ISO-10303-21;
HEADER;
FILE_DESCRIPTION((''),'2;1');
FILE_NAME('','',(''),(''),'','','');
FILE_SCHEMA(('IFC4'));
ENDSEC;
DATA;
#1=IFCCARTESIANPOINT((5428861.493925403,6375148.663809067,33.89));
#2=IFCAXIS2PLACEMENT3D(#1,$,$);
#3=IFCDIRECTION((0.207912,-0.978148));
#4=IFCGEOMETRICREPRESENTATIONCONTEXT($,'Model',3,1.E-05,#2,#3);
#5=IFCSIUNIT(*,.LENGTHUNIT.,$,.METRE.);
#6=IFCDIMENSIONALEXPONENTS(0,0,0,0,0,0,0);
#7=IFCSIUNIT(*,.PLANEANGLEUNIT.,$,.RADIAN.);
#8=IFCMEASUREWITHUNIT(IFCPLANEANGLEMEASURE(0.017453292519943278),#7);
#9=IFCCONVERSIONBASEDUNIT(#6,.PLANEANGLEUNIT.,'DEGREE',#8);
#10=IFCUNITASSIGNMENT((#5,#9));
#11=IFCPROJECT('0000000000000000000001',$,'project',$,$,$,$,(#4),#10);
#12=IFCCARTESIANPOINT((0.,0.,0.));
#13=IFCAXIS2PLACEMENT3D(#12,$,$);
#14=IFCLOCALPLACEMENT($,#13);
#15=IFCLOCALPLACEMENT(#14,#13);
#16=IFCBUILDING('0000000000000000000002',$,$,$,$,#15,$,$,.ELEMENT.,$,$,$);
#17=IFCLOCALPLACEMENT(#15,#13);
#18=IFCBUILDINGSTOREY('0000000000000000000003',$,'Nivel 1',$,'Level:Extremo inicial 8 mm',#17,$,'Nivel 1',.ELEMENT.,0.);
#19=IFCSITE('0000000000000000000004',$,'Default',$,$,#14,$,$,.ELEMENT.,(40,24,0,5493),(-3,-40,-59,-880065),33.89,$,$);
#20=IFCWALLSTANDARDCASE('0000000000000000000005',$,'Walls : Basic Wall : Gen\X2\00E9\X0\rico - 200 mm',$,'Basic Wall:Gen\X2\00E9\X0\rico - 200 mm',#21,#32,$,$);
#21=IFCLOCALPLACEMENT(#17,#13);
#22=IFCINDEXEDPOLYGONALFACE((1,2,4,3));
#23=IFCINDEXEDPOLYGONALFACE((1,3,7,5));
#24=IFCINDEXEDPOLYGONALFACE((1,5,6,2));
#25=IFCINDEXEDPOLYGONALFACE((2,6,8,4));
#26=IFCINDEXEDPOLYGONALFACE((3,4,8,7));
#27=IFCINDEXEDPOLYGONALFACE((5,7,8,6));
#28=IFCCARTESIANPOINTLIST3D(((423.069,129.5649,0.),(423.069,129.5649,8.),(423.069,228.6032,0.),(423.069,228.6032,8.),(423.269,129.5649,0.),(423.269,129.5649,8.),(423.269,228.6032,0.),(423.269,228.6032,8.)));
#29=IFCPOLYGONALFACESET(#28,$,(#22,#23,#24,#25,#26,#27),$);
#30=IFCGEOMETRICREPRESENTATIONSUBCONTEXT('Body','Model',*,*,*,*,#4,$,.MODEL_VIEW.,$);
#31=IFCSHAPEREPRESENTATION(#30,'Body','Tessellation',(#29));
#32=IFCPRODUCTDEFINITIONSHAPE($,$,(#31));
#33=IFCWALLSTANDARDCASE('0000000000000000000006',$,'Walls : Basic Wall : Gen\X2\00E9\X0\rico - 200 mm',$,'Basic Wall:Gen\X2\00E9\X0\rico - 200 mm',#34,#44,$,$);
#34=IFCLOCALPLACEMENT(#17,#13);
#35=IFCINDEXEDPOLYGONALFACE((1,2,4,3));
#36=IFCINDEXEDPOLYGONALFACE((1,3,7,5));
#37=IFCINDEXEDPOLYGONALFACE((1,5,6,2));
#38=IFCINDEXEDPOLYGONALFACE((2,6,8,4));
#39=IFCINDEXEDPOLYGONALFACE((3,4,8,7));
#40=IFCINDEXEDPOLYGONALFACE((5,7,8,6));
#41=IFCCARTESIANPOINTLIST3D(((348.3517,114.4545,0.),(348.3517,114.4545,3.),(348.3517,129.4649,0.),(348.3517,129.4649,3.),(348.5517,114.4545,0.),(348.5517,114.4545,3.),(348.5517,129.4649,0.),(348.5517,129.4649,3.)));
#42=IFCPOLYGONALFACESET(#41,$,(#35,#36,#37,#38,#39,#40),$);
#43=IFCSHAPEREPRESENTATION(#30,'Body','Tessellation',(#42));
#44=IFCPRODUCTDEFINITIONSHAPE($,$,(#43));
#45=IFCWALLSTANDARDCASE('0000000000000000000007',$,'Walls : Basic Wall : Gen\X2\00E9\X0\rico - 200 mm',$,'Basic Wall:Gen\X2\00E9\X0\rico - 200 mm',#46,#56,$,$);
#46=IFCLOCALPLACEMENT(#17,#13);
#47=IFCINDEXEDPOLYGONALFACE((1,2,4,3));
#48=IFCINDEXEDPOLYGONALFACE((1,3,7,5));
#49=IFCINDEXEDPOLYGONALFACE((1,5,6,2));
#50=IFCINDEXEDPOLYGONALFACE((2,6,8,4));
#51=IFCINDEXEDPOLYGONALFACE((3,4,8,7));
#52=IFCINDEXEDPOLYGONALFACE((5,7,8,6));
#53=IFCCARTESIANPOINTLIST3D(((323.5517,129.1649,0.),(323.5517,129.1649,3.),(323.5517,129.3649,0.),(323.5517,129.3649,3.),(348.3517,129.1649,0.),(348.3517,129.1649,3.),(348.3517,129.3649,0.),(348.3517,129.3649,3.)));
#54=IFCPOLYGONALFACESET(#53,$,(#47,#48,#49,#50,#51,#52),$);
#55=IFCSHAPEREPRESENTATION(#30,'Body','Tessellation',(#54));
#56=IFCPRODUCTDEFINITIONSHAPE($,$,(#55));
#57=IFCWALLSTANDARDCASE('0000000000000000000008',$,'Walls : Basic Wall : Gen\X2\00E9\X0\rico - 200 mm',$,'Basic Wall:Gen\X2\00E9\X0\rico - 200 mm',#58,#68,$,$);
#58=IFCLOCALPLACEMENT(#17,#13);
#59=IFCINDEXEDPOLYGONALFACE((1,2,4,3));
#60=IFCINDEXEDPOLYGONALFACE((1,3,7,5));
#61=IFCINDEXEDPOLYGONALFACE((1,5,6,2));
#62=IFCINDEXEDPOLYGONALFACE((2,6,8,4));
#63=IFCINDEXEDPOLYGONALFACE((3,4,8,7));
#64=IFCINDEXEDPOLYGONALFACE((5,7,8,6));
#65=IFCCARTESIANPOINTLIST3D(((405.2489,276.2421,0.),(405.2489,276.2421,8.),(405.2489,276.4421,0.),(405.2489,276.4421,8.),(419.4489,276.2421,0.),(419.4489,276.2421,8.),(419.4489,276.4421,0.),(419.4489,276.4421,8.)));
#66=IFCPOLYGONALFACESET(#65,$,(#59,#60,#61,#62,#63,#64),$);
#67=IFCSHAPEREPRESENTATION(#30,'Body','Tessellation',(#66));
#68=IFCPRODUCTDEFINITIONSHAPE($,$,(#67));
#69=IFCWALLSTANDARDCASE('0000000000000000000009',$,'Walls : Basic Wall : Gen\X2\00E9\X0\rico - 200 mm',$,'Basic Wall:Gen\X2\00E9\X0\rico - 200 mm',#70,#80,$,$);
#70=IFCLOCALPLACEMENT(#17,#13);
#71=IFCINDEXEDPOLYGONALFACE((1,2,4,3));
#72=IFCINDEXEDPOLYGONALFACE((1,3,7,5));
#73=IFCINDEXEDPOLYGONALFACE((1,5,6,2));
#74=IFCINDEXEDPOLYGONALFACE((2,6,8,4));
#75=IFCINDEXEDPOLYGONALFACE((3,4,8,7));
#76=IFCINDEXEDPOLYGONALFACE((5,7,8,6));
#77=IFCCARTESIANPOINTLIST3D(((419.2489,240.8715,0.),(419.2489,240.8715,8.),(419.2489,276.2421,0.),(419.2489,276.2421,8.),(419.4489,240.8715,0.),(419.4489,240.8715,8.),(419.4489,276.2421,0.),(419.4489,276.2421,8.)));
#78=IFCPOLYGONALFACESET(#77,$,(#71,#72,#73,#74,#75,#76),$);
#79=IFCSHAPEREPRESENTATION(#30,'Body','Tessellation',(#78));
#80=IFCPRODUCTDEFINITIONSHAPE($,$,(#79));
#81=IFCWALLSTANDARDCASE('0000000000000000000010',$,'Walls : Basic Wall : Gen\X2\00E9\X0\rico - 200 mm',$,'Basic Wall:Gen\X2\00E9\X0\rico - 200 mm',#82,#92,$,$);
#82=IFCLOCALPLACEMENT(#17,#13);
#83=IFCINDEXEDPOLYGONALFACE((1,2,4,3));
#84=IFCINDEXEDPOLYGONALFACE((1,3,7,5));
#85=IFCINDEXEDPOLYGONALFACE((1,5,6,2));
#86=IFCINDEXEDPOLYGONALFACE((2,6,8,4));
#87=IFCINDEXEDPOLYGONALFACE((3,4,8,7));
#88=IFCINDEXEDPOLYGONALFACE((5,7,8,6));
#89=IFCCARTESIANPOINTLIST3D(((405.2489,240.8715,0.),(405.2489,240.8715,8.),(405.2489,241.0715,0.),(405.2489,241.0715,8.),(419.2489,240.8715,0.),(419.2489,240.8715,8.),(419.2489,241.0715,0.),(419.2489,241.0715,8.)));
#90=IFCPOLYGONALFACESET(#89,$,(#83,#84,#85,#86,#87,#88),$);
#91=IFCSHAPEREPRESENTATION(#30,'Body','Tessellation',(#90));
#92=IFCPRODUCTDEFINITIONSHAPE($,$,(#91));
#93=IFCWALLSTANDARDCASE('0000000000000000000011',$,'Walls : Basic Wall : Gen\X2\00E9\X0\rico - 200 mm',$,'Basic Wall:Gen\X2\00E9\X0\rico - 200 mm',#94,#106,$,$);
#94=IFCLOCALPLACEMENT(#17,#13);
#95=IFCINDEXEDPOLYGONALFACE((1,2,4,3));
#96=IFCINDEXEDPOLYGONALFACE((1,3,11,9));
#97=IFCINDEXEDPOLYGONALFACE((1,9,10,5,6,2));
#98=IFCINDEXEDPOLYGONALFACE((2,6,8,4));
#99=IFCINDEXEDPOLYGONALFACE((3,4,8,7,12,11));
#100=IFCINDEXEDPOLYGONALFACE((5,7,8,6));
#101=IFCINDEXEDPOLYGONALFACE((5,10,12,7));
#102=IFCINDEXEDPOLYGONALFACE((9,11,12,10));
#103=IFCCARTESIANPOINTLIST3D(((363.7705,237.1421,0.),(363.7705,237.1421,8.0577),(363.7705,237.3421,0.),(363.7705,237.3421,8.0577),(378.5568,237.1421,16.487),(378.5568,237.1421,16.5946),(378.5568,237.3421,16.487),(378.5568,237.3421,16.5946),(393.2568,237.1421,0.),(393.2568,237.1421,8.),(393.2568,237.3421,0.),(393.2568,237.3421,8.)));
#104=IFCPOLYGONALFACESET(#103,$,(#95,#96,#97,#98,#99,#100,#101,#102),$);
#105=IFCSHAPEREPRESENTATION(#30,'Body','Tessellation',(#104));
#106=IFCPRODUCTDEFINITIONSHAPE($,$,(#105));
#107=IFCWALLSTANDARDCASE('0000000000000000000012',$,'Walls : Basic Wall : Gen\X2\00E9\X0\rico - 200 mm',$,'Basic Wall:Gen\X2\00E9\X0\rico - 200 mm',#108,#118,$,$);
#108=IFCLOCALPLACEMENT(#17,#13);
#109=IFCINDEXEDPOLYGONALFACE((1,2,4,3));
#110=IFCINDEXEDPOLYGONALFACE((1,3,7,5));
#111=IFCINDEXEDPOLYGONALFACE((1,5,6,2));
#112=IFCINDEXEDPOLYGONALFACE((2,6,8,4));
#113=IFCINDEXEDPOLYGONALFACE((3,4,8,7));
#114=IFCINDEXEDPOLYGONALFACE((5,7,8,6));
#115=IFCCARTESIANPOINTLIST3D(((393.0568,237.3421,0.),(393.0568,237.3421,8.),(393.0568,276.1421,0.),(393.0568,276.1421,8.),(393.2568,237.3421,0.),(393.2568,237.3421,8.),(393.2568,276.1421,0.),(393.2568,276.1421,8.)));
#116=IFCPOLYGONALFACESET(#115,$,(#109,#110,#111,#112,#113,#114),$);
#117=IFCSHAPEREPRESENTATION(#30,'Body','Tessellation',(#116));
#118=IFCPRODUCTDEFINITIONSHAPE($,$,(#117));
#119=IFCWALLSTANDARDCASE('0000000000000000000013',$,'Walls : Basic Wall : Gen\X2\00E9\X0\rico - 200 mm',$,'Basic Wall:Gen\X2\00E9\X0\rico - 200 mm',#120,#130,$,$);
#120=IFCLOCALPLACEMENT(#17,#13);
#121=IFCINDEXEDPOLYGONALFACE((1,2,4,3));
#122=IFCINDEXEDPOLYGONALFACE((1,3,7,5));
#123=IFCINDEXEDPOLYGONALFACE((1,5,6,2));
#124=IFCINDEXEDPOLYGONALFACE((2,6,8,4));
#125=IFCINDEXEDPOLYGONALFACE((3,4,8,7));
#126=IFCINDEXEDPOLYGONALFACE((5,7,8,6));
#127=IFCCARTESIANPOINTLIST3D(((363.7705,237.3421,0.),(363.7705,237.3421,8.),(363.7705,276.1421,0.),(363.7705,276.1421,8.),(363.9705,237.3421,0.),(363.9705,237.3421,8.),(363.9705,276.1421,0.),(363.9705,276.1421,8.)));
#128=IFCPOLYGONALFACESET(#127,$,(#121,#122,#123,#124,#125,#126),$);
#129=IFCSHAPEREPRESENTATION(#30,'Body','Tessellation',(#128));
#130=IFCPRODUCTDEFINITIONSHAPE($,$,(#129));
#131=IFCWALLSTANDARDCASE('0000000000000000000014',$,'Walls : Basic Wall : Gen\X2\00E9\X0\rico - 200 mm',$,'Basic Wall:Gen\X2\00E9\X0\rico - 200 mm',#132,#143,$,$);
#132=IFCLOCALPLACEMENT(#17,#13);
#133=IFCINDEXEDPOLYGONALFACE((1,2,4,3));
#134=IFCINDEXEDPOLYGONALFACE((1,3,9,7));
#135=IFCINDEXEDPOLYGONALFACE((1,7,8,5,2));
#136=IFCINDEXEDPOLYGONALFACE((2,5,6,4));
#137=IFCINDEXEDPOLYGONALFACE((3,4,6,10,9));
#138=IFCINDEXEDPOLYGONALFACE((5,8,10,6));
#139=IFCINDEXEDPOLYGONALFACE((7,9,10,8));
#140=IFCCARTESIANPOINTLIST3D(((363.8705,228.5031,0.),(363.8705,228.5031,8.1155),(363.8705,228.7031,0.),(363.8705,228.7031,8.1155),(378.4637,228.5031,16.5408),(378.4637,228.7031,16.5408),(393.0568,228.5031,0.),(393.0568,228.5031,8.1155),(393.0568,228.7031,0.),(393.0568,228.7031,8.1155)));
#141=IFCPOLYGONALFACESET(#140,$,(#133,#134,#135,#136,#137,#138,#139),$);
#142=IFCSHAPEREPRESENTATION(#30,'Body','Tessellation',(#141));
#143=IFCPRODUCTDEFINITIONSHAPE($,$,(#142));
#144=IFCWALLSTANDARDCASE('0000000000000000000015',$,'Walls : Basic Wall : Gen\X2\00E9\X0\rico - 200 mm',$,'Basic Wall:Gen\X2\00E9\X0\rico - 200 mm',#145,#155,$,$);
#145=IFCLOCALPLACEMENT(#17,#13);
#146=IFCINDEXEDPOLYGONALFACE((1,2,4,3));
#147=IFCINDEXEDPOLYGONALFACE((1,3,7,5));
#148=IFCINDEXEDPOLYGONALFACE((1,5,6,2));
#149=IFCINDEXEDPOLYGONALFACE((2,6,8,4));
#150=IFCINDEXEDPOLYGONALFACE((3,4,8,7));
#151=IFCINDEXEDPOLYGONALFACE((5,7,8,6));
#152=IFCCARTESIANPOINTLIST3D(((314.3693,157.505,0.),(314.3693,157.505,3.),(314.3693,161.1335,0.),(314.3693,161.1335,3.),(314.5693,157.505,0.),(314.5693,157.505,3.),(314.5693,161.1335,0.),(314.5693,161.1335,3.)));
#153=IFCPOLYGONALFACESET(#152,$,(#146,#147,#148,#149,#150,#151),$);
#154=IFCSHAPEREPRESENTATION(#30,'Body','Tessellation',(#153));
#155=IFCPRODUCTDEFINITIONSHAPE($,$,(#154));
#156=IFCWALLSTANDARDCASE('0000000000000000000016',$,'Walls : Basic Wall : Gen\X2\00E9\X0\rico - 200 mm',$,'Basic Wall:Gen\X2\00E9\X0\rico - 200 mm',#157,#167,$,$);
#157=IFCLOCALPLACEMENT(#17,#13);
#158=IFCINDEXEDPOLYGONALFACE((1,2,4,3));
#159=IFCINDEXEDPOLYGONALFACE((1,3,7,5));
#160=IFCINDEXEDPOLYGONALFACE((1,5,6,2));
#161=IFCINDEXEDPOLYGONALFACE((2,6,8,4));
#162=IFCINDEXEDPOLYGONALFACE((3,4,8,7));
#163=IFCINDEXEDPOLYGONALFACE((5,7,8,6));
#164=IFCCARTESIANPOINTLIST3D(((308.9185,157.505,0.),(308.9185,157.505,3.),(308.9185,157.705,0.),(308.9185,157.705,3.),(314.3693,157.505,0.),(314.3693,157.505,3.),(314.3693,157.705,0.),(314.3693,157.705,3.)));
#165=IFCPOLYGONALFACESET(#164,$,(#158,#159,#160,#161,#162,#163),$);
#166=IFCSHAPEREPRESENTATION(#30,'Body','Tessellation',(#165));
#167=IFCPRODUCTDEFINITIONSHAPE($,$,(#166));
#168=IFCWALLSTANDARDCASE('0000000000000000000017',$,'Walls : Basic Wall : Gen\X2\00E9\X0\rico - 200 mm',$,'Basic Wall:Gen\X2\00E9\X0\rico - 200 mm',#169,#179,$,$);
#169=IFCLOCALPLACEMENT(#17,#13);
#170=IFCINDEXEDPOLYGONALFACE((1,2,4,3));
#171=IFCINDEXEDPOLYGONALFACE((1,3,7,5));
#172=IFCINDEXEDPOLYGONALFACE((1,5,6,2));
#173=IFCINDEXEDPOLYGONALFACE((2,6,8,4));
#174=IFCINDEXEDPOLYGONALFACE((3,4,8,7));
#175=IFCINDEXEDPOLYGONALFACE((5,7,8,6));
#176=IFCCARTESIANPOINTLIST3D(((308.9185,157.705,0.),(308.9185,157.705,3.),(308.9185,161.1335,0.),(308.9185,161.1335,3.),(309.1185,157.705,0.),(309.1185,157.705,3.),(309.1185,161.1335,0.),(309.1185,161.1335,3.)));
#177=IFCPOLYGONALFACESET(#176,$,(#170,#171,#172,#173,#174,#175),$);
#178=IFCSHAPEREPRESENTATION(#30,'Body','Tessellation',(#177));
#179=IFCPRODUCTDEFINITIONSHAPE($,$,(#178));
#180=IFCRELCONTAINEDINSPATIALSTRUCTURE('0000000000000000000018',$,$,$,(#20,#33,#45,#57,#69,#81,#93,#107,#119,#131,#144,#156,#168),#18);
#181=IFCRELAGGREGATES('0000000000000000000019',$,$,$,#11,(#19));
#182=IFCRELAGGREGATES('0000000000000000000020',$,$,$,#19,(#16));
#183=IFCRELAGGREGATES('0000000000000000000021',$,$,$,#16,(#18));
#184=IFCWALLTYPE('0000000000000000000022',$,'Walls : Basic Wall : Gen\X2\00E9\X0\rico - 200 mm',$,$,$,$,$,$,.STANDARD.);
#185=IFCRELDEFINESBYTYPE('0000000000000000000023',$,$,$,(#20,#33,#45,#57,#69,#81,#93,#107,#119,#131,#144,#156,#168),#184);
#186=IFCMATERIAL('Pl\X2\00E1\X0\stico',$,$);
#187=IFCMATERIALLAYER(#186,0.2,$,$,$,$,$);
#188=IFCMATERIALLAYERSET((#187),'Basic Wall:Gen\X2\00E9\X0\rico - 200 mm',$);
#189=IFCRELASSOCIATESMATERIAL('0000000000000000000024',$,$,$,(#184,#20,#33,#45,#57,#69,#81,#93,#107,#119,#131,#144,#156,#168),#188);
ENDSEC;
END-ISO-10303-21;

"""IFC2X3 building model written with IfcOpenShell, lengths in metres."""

from ifc_helpers import new_model, entity, si_unit, converted_unit, direction, frame, frame_2d, origin, place, context, subcontext, project, spatial, polyline, rectangle, extrude, clip, bounded_halfspace, material, layer, layer_set, layer_usage, type_object, element, save


model = new_model("IFC2X3")

# Units and contexts
model_context = context("Model", 3, precision=1e-05, world=frame((5428861.493925403, 6375148.663809067, 33.89)), true_north=direction((0.207912, -0.978148)))
body_context = subcontext(model_context, "Body", "Model", "MODEL_VIEW")
ifc_project = project(units=[si_unit("LENGTHUNIT", "METRE"), converted_unit("PLANEANGLEUNIT", "DEGREE", entity("IfcPlaneAngleMeasure", 0.017453292519943278), si_unit("PLANEANGLEUNIT", "RADIAN"), dimensions=[0, 0, 0, 0, 0, 0, 0])], contexts=[model_context])

# Site, building, storey
site_placement = place(None, origin())
site = spatial("IfcSite", under=ifc_project, at=site_placement, Name="Default", CompositionType="ELEMENT", RefLatitude=(40, 24, 0, 5493), RefLongitude=(-3, -40, -59, -880065), RefElevation=33.89)
building_placement = place(site_placement, origin())
building = spatial("IfcBuilding", under=site, at=building_placement, CompositionType="ELEMENT")
storey_placement = place(building_placement, origin())
storey = spatial("IfcBuildingStorey", under=building, at=storey_placement, Name="Nivel 1", ObjectType="Level:Extremo inicial 8 mm", LongName="Nivel 1", CompositionType="ELEMENT", Elevation=0.0)

# Walls
ifc_material = material(Name="Plástico")
ifc_layer = layer(ifc_material, 0.2)
ifc_layer_set = layer_set([ifc_layer], Name="Basic Wall:Genérico - 200 mm")
wall_type = type_object("IfcWallType", Name="Walls : Basic Wall : Genérico - 200 mm", PredefinedType="STANDARD", material=ifc_layer_set)
ifc_layer_usage_1 = layer_usage(ifc_layer_set, "AXIS2", "NEGATIVE", 0.1)
wall_1_placement = place(storey_placement, frame((423.169, 129.5649, 0.0), z_axis=(0.0, 0.0, 1.0), x_axis=(0.0, 1.0, 0.0)))
element("IfcWallStandardCase", 1, at=wall_1_placement, inside=storey, type_object=wall_type, material=ifc_layer_usage_1, Name="Walls : Basic Wall : Genérico - 200 mm", ObjectType="Basic Wall:Genérico - 200 mm", context=body_context, shape_type="SweptSolid", body=[
    extrude(rectangle(XDim=99.0383, YDim=0.2, at=frame_2d((49.5191, 0.0), x_axis=(-1.0, 0.0))), origin(), (0.0, 0.0, 1.0), 8.0),
])
ifc_layer_usage_2 = layer_usage(ifc_layer_set, "AXIS2", "NEGATIVE", 0.1)
wall_2_placement = place(storey_placement, frame((348.4517, 129.4649, 0.0), z_axis=(0.0, 0.0, 1.0), x_axis=(0.0, -1.0, 0.0)))
element("IfcWallStandardCase", 2, at=wall_2_placement, inside=storey, type_object=wall_type, material=ifc_layer_usage_2, Name="Walls : Basic Wall : Genérico - 200 mm", ObjectType="Basic Wall:Genérico - 200 mm", context=body_context, shape_type="SweptSolid", body=[
    extrude(rectangle(XDim=15.0104, YDim=0.2, at=frame_2d((7.5052, 0.0), x_axis=(-1.0, 0.0))), origin(), (0.0, 0.0, 1.0), 3.0),
])
ifc_layer_usage_3 = layer_usage(ifc_layer_set, "AXIS2", "NEGATIVE", 0.1)
wall_3_placement = place(storey_placement, frame((348.3517, 129.2649, 0.0), z_axis=(0.0, 0.0, 1.0), x_axis=(-1.0, 0.0, 0.0)))
element("IfcWallStandardCase", 3, at=wall_3_placement, inside=storey, type_object=wall_type, material=ifc_layer_usage_3, Name="Walls : Basic Wall : Genérico - 200 mm", ObjectType="Basic Wall:Genérico - 200 mm", context=body_context, shape_type="SweptSolid", body=[
    extrude(rectangle(XDim=24.8, YDim=0.2, at=frame_2d((12.4, 0.0), x_axis=(-1.0, 0.0))), origin(), (0.0, 0.0, 1.0), 3.0),
])
ifc_layer_usage_4 = layer_usage(ifc_layer_set, "AXIS2", "NEGATIVE", 0.1)
wall_4_placement = place(storey_placement, frame((405.2489, 276.3421, 0.0)))
element("IfcWallStandardCase", 4, at=wall_4_placement, inside=storey, type_object=wall_type, material=ifc_layer_usage_4, Name="Walls : Basic Wall : Genérico - 200 mm", ObjectType="Basic Wall:Genérico - 200 mm", context=body_context, shape_type="SweptSolid", body=[
    extrude(rectangle(XDim=14.2, YDim=0.2, at=frame_2d((7.1, 0.0), x_axis=(-1.0, 0.0))), origin(), (0.0, 0.0, 1.0), 8.0),
])
ifc_layer_usage_5 = layer_usage(ifc_layer_set, "AXIS2", "NEGATIVE", 0.1)
wall_5_placement = place(storey_placement, frame((419.3489, 240.8715, 0.0), z_axis=(0.0, 0.0, 1.0), x_axis=(0.0, 1.0, 0.0)))
element("IfcWallStandardCase", 5, at=wall_5_placement, inside=storey, type_object=wall_type, material=ifc_layer_usage_5, Name="Walls : Basic Wall : Genérico - 200 mm", ObjectType="Basic Wall:Genérico - 200 mm", context=body_context, shape_type="SweptSolid", body=[
    extrude(rectangle(XDim=35.3706, YDim=0.2, at=frame_2d((17.6853, 0.0), x_axis=(-1.0, 0.0))), origin(), (0.0, 0.0, 1.0), 8.0),
])
ifc_layer_usage_6 = layer_usage(ifc_layer_set, "AXIS2", "NEGATIVE", 0.1)
wall_6_placement = place(storey_placement, frame((419.2489, 240.9715, 0.0), z_axis=(0.0, 0.0, 1.0), x_axis=(-1.0, 0.0, 0.0)))
element("IfcWallStandardCase", 6, at=wall_6_placement, inside=storey, type_object=wall_type, material=ifc_layer_usage_6, Name="Walls : Basic Wall : Genérico - 200 mm", ObjectType="Basic Wall:Genérico - 200 mm", context=body_context, shape_type="Clipping", body=[
    clip(extrude(rectangle(XDim=14.0, YDim=0.2, at=frame_2d((7.0, 0.0), x_axis=(-1.0, 0.0))), origin(), (0.0, 0.0, 1.0), 8.0), bounded_halfspace(frame((0.0, -0.1, 8.0), z_axis=(0.0, 0.0, 1.0), x_axis=(-1.0, 0.0, 0.0)), False, frame((0.0, -0.1, 8.0)), polyline([(0.0, 0.0), (14.0, 0.0), (14.0, 0.2), (0.0, 0.2), (0.0, 0.0)]))),
])
ifc_layer_usage_7 = layer_usage(ifc_layer_set, "AXIS2", "NEGATIVE", 0.1)
wall_7_placement = place(storey_placement, frame((363.7705, 237.2421, 0.0)))
element("IfcWallStandardCase", 7, at=wall_7_placement, inside=storey, type_object=wall_type, material=ifc_layer_usage_7, Name="Walls : Basic Wall : Genérico - 200 mm", ObjectType="Basic Wall:Genérico - 200 mm", context=body_context, shape_type="Clipping", body=[
    clip(clip(extrude(rectangle(XDim=29.4863, YDim=0.2, at=frame_2d((14.7431, 0.0), x_axis=(-1.0, 0.0))), origin(), (0.0, 0.0, 1.0), 16.5946), bounded_halfspace(frame((0.0, -0.1, 8.0577), z_axis=(-0.5, 0.0, 0.866025), x_axis=(0.0, -1.0, 0.0)), False, frame((0.0, -0.1, 8.0577)), polyline([(0.0, 0.0), (14.7863, 0.0), (14.7863, 0.2), (0.0, 0.2), (0.0, 0.0)]))), bounded_halfspace(frame((14.7863, -0.1, 16.487), z_axis=(0.5, 0.0, 0.866025), x_axis=(0.0, 1.0, 0.0)), False, frame((14.7863, -0.1, 16.487)), polyline([(0.0, 0.0), (14.7, 0.0), (14.7, 0.2), (0.0, 0.2), (0.0, 0.0)]))),
])
ifc_layer_usage_8 = layer_usage(ifc_layer_set, "AXIS2", "NEGATIVE", 0.1)
wall_8_placement = place(storey_placement, frame((393.1568, 237.3421, 0.0), z_axis=(0.0, 0.0, 1.0), x_axis=(0.0, 1.0, 0.0)))
element("IfcWallStandardCase", 8, at=wall_8_placement, inside=storey, type_object=wall_type, material=ifc_layer_usage_8, Name="Walls : Basic Wall : Genérico - 200 mm", ObjectType="Basic Wall:Genérico - 200 mm", context=body_context, shape_type="SweptSolid", body=[
    extrude(rectangle(XDim=38.8, YDim=0.2, at=frame_2d((19.4, 0.0), x_axis=(-1.0, 0.0))), origin(), (0.0, 0.0, 1.0), 8.0),
])
ifc_layer_usage_9 = layer_usage(ifc_layer_set, "AXIS2", "NEGATIVE", 0.1)
wall_9_placement = place(storey_placement, frame((363.8705, 237.3421, 0.0), z_axis=(0.0, 0.0, 1.0), x_axis=(0.0, 1.0, 0.0)))
element("IfcWallStandardCase", 9, at=wall_9_placement, inside=storey, type_object=wall_type, material=ifc_layer_usage_9, Name="Walls : Basic Wall : Genérico - 200 mm", ObjectType="Basic Wall:Genérico - 200 mm", context=body_context, shape_type="SweptSolid", body=[
    extrude(rectangle(XDim=38.8, YDim=0.2, at=frame_2d((19.4, 0.0), x_axis=(-1.0, 0.0))), origin(), (0.0, 0.0, 1.0), 8.0),
])
ifc_layer_usage_10 = layer_usage(ifc_layer_set, "AXIS2", "NEGATIVE", 0.1)
wall_10_placement = place(storey_placement, frame((363.8705, 228.6031, 0.0)))
element("IfcWallStandardCase", 10, at=wall_10_placement, inside=storey, type_object=wall_type, material=ifc_layer_usage_10, Name="Walls : Basic Wall : Genérico - 200 mm", ObjectType="Basic Wall:Genérico - 200 mm", context=body_context, shape_type="Clipping", body=[
    clip(clip(extrude(rectangle(XDim=29.1863, YDim=0.2, at=frame_2d((14.5931, 0.0), x_axis=(-1.0, 0.0))), origin(), (0.0, 0.0, 1.0), 16.5408), bounded_halfspace(frame((0.0, -0.1, 8.1155), z_axis=(-0.5, 0.0, 0.866025), x_axis=(0.0, -1.0, 0.0)), False, frame((0.0, -0.1, 8.1155)), polyline([(0.0, 0.0), (14.5931, 0.0), (14.5931, 0.2), (0.0, 0.2), (0.0, 0.0)]))), bounded_halfspace(frame((14.5931, -0.1, 16.5408), z_axis=(0.5, 0.0, 0.866025), x_axis=(0.0, 1.0, 0.0)), False, frame((14.5931, -0.1, 16.5408)), polyline([(0.0, 0.0), (14.5931, 0.0), (14.5931, 0.2), (0.0, 0.2), (0.0, 0.0)]))),
])
ifc_layer_usage_11 = layer_usage(ifc_layer_set, "AXIS2", "NEGATIVE", 0.1)
wall_11_placement = place(storey_placement, frame((314.4693, 161.1335, 0.0), z_axis=(0.0, 0.0, 1.0), x_axis=(0.0, -1.0, 0.0)))
element("IfcWallStandardCase", 11, at=wall_11_placement, inside=storey, type_object=wall_type, material=ifc_layer_usage_11, Name="Walls : Basic Wall : Genérico - 200 mm", ObjectType="Basic Wall:Genérico - 200 mm", context=body_context, shape_type="SweptSolid", body=[
    extrude(rectangle(XDim=3.6285, YDim=0.2, at=frame_2d((1.8142, 0.0), x_axis=(-1.0, 0.0))), origin(), (0.0, 0.0, 1.0), 3.0),
])
ifc_layer_usage_12 = layer_usage(ifc_layer_set, "AXIS2", "NEGATIVE", 0.1)
wall_12_placement = place(storey_placement, frame((314.3693, 157.605, 0.0), z_axis=(0.0, 0.0, 1.0), x_axis=(-1.0, 0.0, 0.0)))
element("IfcWallStandardCase", 12, at=wall_12_placement, inside=storey, type_object=wall_type, material=ifc_layer_usage_12, Name="Walls : Basic Wall : Genérico - 200 mm", ObjectType="Basic Wall:Genérico - 200 mm", context=body_context, shape_type="SweptSolid", body=[
    extrude(rectangle(XDim=5.4508, YDim=0.2, at=frame_2d((2.7254, 0.0), x_axis=(-1.0, 0.0))), origin(), (0.0, 0.0, 1.0), 3.0),
])
ifc_layer_usage_13 = layer_usage(ifc_layer_set, "AXIS2", "NEGATIVE", 0.1)
wall_13_placement = place(storey_placement, frame((309.0185, 157.705, 0.0), z_axis=(0.0, 0.0, 1.0), x_axis=(0.0, 1.0, 0.0)))
element("IfcWallStandardCase", 13, at=wall_13_placement, inside=storey, type_object=wall_type, material=ifc_layer_usage_13, Name="Walls : Basic Wall : Genérico - 200 mm", ObjectType="Basic Wall:Genérico - 200 mm", context=body_context, shape_type="SweptSolid", body=[
    extrude(rectangle(XDim=3.4285, YDim=0.2, at=frame_2d((1.7142, 0.0), x_axis=(-1.0, 0.0))), origin(), (0.0, 0.0, 1.0), 3.0),
])

save(model, "model.ifc")
